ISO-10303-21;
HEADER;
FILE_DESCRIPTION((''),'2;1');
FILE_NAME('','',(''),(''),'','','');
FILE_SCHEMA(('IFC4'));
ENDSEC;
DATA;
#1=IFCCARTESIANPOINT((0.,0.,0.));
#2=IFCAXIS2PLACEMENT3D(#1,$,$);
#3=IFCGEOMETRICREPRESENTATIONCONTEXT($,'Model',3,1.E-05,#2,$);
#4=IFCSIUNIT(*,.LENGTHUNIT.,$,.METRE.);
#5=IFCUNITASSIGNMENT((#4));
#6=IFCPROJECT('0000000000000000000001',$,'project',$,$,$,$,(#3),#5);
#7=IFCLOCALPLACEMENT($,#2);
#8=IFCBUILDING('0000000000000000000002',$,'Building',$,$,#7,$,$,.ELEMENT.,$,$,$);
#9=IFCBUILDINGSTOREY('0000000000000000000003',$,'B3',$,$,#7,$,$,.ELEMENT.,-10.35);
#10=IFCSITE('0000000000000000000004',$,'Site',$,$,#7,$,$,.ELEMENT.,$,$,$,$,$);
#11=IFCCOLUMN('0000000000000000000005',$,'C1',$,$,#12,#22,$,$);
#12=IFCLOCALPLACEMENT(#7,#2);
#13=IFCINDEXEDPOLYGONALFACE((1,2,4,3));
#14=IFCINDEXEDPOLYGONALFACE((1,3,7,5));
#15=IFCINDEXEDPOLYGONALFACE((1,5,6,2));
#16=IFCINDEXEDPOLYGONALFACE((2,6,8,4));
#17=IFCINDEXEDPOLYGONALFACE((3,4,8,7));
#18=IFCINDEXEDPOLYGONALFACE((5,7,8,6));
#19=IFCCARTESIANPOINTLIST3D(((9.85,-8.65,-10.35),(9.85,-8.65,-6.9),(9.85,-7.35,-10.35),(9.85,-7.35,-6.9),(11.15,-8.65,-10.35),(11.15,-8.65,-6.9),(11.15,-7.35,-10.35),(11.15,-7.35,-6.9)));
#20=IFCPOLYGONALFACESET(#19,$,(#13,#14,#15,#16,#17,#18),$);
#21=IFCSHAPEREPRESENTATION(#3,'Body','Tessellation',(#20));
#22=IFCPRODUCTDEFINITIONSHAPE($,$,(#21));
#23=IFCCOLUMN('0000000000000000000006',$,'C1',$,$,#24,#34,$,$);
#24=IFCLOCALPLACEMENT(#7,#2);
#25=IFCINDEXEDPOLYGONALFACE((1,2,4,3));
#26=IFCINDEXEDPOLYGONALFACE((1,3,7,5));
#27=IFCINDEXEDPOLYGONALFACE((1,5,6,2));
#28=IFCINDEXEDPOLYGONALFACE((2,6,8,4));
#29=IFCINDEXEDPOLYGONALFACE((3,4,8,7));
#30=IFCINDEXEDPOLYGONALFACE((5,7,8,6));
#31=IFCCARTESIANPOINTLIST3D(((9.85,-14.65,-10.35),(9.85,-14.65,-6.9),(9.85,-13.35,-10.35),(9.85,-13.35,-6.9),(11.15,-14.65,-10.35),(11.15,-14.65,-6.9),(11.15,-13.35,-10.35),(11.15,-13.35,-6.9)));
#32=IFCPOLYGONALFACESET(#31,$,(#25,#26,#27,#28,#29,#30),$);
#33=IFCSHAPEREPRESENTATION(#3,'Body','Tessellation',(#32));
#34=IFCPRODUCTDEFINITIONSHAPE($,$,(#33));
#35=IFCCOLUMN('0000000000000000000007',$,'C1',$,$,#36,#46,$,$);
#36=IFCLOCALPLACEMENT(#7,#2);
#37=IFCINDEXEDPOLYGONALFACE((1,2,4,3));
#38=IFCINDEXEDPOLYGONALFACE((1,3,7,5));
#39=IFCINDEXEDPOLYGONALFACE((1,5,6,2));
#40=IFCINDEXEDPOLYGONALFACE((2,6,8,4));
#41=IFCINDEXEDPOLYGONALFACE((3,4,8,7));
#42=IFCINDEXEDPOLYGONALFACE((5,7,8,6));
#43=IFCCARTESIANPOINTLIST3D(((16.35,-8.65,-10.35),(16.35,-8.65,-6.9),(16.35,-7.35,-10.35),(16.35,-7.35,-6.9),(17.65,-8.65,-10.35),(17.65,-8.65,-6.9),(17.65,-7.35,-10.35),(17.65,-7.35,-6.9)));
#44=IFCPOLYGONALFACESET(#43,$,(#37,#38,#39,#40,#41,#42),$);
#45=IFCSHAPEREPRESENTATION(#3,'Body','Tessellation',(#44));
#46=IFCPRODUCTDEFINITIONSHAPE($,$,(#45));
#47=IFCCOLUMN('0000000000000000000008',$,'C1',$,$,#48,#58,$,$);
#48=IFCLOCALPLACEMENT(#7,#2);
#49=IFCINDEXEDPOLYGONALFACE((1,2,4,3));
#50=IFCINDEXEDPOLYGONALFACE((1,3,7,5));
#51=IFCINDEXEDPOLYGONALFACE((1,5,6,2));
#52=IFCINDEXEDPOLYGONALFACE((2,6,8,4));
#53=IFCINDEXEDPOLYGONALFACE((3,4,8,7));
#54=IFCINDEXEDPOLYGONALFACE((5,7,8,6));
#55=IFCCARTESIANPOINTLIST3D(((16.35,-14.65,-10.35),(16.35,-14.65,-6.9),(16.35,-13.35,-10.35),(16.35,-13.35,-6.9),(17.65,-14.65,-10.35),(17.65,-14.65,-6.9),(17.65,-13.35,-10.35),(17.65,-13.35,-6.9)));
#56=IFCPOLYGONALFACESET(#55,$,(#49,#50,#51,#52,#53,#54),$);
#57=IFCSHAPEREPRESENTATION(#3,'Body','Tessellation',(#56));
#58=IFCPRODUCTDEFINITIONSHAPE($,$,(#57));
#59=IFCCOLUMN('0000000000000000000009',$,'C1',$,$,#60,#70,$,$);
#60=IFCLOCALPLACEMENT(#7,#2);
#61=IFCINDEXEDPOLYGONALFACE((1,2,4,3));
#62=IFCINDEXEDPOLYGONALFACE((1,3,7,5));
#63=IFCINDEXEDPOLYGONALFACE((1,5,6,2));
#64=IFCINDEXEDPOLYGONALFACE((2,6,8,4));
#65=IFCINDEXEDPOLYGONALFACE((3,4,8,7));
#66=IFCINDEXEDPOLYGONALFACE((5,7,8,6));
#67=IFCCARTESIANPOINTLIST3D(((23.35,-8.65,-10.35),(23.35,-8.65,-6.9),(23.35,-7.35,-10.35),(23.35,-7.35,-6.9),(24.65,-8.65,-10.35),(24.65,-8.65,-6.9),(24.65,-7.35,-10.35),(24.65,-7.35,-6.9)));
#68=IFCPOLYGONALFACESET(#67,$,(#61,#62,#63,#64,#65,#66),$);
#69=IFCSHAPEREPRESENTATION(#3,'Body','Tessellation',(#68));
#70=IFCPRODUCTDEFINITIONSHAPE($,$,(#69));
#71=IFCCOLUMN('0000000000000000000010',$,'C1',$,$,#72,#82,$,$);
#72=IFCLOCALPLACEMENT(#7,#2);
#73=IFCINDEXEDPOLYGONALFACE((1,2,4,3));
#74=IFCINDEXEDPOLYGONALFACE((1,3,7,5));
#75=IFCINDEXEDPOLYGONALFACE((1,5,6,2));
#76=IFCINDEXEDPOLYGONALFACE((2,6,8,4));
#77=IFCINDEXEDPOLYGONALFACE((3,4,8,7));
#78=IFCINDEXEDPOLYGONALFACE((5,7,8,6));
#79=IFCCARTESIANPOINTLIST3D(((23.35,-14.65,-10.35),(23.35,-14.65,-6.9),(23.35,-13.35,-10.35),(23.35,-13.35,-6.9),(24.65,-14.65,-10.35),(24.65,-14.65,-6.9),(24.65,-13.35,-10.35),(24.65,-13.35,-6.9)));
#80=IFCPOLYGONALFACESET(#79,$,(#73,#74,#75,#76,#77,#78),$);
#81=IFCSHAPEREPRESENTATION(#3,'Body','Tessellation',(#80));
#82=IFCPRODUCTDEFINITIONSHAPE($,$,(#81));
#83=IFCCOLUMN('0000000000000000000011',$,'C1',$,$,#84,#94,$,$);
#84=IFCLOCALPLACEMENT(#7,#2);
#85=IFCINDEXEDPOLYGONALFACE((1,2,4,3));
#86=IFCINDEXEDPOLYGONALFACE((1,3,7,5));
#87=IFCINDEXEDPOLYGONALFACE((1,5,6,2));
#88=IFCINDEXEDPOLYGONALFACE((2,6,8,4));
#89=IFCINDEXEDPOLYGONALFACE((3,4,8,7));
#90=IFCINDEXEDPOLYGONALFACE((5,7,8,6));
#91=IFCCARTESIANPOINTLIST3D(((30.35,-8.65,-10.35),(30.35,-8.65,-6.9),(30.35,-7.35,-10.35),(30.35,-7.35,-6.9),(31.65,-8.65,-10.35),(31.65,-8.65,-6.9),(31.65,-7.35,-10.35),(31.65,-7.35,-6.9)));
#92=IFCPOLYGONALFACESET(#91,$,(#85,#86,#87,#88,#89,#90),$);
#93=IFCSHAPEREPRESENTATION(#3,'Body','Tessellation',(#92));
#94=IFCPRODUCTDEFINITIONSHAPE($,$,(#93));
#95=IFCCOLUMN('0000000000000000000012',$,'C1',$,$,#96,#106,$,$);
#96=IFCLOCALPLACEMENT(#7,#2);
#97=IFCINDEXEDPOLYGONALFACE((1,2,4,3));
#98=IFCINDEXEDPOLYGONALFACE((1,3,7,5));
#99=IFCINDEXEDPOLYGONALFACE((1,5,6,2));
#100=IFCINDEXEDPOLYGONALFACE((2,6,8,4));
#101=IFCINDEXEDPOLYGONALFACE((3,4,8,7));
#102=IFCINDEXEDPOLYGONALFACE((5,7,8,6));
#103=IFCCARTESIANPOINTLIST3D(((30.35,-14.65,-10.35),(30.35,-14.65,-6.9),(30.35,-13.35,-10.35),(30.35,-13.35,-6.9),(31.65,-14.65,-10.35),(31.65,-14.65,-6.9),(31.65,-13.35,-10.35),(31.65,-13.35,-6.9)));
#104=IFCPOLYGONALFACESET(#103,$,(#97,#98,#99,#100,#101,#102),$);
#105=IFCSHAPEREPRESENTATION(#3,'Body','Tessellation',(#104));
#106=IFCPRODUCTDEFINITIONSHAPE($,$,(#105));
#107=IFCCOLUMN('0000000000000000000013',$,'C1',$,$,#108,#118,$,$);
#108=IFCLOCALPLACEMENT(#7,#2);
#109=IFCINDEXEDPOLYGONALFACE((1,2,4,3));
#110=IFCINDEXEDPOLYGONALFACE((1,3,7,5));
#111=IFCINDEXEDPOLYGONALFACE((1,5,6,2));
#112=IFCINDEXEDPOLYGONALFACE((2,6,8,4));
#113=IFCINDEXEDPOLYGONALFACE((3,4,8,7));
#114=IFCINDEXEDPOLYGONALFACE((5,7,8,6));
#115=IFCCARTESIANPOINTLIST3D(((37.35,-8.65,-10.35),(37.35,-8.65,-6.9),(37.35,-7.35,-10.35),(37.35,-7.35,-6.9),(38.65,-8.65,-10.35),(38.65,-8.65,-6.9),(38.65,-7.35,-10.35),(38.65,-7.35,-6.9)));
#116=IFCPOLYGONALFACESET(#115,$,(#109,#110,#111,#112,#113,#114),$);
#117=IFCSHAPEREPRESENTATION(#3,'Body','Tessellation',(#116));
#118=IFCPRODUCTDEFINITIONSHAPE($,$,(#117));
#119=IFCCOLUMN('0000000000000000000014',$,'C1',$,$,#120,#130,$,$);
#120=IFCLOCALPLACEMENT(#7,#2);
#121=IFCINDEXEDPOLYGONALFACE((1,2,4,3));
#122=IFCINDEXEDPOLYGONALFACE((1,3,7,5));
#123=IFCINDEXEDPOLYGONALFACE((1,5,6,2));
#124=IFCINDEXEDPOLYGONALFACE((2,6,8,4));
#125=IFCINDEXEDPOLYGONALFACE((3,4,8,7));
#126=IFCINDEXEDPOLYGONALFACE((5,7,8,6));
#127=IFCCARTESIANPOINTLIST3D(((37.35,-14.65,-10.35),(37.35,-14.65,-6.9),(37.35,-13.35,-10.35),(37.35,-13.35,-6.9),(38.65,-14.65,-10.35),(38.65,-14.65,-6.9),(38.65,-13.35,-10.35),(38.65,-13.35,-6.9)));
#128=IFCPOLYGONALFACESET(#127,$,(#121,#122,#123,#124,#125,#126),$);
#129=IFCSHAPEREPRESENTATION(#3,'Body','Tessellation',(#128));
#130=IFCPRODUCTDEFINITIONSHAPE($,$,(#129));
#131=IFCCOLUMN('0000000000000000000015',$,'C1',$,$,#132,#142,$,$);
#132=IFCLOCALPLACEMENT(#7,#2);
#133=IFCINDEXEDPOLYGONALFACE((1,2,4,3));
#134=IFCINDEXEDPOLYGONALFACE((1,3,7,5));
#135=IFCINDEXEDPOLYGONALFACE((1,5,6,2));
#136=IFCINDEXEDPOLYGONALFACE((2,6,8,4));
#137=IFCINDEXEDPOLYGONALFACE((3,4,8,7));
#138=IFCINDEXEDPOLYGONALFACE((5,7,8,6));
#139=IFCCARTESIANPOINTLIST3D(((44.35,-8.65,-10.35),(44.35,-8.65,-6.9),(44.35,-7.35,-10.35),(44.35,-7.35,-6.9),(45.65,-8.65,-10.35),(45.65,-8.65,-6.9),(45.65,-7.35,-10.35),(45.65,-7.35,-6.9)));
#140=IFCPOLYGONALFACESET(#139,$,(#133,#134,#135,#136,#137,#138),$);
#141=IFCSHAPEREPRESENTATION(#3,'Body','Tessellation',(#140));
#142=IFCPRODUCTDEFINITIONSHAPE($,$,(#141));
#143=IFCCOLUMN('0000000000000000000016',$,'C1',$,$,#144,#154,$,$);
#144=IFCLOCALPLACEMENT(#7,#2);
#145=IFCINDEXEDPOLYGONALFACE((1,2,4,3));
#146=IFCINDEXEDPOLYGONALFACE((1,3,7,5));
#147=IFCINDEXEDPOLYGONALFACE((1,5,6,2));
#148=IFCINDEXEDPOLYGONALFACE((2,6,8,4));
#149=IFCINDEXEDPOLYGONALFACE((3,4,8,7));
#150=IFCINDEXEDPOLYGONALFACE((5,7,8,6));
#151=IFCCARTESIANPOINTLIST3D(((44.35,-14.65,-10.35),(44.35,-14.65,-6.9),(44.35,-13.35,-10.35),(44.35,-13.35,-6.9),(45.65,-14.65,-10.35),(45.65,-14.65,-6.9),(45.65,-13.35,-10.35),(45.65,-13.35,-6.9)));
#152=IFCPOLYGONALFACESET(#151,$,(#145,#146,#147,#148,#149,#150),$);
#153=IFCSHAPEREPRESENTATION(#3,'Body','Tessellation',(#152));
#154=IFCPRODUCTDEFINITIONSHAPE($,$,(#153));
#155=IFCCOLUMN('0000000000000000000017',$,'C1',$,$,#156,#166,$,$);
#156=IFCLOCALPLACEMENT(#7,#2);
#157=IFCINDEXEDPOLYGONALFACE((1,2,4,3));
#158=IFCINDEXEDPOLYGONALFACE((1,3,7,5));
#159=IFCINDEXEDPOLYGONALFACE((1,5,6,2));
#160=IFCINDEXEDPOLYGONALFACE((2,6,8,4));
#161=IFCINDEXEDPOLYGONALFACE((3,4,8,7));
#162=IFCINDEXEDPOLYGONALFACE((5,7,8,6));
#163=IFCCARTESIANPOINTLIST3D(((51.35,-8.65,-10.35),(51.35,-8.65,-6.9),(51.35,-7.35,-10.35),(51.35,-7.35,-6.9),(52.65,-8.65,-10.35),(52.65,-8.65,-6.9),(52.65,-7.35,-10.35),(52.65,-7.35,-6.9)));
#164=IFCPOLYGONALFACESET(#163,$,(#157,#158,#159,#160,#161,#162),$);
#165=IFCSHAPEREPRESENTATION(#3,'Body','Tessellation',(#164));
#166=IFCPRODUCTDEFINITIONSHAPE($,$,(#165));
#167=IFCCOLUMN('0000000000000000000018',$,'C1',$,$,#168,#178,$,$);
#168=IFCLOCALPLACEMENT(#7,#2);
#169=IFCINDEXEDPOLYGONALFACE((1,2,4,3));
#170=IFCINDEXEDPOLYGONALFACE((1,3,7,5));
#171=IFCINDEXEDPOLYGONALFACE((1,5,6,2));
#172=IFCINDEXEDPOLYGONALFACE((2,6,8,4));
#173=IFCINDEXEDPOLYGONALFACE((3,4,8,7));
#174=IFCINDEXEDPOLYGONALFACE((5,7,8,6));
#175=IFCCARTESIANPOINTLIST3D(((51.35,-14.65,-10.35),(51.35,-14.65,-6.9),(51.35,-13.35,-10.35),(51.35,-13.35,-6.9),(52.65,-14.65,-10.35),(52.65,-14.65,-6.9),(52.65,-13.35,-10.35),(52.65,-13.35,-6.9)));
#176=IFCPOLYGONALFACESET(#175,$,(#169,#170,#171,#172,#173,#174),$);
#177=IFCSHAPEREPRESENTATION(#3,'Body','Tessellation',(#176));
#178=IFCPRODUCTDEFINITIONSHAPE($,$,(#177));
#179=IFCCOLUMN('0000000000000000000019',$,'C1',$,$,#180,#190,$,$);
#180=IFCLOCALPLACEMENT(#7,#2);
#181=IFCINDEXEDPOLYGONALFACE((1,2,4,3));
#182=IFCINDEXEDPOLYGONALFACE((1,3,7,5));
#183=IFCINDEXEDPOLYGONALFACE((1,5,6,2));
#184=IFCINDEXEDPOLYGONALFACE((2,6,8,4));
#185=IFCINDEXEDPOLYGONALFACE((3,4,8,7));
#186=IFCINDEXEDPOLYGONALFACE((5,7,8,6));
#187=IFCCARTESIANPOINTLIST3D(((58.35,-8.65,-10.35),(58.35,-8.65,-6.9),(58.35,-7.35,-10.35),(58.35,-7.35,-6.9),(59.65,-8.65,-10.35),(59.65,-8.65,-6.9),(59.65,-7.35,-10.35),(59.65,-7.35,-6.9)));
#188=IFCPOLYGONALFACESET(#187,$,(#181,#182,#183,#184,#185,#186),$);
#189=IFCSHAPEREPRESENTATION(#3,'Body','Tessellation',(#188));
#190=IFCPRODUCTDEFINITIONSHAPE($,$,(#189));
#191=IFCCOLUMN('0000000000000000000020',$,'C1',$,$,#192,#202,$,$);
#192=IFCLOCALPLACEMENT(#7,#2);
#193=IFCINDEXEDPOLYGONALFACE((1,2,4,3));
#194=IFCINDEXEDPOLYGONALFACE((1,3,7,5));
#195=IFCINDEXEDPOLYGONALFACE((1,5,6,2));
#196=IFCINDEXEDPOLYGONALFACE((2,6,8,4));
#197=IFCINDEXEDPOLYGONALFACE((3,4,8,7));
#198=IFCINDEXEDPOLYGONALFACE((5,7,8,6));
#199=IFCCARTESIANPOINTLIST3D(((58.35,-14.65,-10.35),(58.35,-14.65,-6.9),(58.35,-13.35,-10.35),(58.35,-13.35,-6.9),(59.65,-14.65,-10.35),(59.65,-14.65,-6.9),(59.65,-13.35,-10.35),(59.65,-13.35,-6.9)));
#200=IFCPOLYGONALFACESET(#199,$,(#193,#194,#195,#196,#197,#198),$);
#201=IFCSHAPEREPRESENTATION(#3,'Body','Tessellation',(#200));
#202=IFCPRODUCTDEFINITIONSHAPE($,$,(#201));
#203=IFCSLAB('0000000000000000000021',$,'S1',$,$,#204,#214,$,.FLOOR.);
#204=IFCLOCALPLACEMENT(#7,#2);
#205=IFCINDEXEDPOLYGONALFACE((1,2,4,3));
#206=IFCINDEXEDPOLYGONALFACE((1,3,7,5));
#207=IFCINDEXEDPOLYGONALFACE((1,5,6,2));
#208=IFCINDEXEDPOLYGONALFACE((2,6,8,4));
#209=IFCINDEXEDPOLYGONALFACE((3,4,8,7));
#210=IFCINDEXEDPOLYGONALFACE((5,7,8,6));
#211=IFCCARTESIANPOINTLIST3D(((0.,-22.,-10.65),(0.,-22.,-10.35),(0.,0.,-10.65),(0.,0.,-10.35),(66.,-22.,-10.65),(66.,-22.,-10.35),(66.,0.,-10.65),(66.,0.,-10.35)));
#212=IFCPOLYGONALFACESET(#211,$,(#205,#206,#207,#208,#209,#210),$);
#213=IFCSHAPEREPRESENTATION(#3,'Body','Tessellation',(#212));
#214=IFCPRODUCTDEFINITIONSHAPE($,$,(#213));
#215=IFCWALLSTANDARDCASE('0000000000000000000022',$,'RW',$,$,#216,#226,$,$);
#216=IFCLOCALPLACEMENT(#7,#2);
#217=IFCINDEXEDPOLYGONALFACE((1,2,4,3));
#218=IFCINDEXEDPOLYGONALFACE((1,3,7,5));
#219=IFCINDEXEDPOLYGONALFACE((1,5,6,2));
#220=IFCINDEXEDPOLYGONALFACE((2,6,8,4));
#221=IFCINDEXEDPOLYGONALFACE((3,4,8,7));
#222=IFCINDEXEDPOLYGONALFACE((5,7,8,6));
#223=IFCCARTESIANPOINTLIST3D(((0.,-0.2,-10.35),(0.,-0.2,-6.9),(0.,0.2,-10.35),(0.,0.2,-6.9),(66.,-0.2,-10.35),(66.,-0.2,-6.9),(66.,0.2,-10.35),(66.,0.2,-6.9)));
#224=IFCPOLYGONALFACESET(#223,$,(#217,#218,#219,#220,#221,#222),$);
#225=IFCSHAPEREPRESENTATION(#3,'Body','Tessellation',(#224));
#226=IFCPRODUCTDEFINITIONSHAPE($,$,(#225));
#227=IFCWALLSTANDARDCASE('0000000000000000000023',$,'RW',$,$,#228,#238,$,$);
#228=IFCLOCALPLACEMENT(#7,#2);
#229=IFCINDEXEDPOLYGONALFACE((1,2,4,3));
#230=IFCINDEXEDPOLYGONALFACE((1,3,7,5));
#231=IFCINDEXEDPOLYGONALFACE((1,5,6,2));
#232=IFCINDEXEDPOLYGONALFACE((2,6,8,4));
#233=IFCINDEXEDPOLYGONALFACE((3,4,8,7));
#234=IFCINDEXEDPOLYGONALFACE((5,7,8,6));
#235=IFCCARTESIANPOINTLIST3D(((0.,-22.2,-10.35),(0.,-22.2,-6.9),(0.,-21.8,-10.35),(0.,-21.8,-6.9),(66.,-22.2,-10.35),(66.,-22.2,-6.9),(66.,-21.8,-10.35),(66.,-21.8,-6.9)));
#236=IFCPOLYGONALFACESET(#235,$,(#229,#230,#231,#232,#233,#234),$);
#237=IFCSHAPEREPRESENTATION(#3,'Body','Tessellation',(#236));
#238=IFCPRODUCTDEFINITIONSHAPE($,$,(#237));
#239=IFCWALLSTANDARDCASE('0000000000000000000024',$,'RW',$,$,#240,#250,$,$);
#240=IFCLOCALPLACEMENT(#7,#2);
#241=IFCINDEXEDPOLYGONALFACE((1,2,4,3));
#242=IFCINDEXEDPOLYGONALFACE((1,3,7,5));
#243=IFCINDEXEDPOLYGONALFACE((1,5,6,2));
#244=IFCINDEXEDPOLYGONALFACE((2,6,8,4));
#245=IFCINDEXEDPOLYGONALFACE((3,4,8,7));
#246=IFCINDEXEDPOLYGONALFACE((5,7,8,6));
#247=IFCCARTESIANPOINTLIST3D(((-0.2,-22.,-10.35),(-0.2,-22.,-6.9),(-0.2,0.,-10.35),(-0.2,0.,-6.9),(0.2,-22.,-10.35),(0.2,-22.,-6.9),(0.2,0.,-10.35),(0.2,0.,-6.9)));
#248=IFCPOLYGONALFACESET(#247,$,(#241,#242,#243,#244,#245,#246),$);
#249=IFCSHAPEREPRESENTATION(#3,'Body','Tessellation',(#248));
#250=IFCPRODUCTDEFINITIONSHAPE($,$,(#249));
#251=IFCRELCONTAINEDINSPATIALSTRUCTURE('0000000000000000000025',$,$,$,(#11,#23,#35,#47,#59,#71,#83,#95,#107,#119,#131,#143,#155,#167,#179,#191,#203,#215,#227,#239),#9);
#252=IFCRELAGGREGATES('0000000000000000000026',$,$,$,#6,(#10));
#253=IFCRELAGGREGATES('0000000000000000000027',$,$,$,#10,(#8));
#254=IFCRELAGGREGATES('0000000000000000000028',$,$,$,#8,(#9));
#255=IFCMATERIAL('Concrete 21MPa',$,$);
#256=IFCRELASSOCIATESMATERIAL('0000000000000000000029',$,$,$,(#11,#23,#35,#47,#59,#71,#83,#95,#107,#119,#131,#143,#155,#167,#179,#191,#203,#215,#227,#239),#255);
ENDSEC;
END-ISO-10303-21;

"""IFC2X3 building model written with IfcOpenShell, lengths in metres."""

from ifc_helpers import new_model, si_unit, frame, origin, origin_2d, place, context, project, spatial, rectangle, extrude, material, element, save


model = new_model("IFC2X3")

# Units and contexts
model_context = context("Model", 3, precision=1e-05, world=origin())
ifc_project = project(units=[si_unit("LENGTHUNIT", "METRE")], contexts=[model_context])

# Site, building, storey
placement = place(None, origin())
site = spatial("IfcSite", under=ifc_project, at=placement, Name="Site", CompositionType="ELEMENT")
building = spatial("IfcBuilding", under=site, at=placement, Name="Building", CompositionType="ELEMENT")
storey = spatial("IfcBuildingStorey", under=building, at=placement, Name="B3", CompositionType="ELEMENT", Elevation=-10.35)

# Columns
ifc_material_1 = material(Name="Concrete 21MPa")
for number, where, name in (
    (1, (10.5, -8.0, -10.35), "C1"),
    (2, (10.5, -14.0, -10.35), "C1"),
    (3, (17.0, -8.0, -10.35), "C1"),
    (4, (17.0, -14.0, -10.35), "C1"),
    (5, (24.0, -8.0, -10.35), "C1"),
    (6, (24.0, -14.0, -10.35), "C1"),
    (7, (31.0, -8.0, -10.35), "C1"),
    (8, (31.0, -14.0, -10.35), "C1"),
    (9, (38.0, -8.0, -10.35), "C1"),
    (10, (38.0, -14.0, -10.35), "C1"),
    (11, (45.0, -8.0, -10.35), "C1"),
    (12, (45.0, -14.0, -10.35), "C1"),
    (13, (52.0, -8.0, -10.35), "C1"),
    (14, (52.0, -14.0, -10.35), "C1"),
    (15, (59.0, -8.0, -10.35), "C1"),
    (16, (59.0, -14.0, -10.35), "C1"),
):
    element("IfcColumn", number, at=place(None, frame(where)), inside=storey, material=ifc_material_1, Name=name, context=model_context, shape_type="SweptSolid", body=[
        extrude(rectangle(XDim=1.3, YDim=1.3, at=origin_2d()), origin(), (0.0, 0.0, 1.0), 3.45),
    ])

# Slab
slab_placement = place(None, frame((33.0, -11.0, -10.65)))
element("IfcSlab", 17, at=slab_placement, inside=storey, material=ifc_material_1, Name="S1", PredefinedType="FLOOR", context=model_context, shape_type="SweptSolid", body=[
    extrude(rectangle(XDim=66.0, YDim=22.0, at=origin_2d()), origin(), (0.0, 0.0, 1.0), 0.3),
])

# Walls
for number, where, name in (
    (18, (33.0, 0.0, -10.35), "RW"),
    (19, (33.0, -22.0, -10.35), "RW"),
):
    element("IfcWallStandardCase", number, at=place(None, frame(where)), inside=storey, material=ifc_material_1, Name=name, context=model_context, shape_type="SweptSolid", body=[
        extrude(rectangle(XDim=66.0, YDim=0.4, at=origin_2d()), origin(), (0.0, 0.0, 1.0), 3.45),
    ])
for number, where, name in (
    (20, (0.0, -11.0, -10.35), "RW"),
):
    element("IfcWallStandardCase", number, at=place(None, frame(where)), inside=storey, material=ifc_material_1, Name=name, context=model_context, shape_type="SweptSolid", body=[
        extrude(rectangle(XDim=0.4, YDim=22.0, at=origin_2d()), origin(), (0.0, 0.0, 1.0), 3.45),
    ])

save(model, "model.ifc")
